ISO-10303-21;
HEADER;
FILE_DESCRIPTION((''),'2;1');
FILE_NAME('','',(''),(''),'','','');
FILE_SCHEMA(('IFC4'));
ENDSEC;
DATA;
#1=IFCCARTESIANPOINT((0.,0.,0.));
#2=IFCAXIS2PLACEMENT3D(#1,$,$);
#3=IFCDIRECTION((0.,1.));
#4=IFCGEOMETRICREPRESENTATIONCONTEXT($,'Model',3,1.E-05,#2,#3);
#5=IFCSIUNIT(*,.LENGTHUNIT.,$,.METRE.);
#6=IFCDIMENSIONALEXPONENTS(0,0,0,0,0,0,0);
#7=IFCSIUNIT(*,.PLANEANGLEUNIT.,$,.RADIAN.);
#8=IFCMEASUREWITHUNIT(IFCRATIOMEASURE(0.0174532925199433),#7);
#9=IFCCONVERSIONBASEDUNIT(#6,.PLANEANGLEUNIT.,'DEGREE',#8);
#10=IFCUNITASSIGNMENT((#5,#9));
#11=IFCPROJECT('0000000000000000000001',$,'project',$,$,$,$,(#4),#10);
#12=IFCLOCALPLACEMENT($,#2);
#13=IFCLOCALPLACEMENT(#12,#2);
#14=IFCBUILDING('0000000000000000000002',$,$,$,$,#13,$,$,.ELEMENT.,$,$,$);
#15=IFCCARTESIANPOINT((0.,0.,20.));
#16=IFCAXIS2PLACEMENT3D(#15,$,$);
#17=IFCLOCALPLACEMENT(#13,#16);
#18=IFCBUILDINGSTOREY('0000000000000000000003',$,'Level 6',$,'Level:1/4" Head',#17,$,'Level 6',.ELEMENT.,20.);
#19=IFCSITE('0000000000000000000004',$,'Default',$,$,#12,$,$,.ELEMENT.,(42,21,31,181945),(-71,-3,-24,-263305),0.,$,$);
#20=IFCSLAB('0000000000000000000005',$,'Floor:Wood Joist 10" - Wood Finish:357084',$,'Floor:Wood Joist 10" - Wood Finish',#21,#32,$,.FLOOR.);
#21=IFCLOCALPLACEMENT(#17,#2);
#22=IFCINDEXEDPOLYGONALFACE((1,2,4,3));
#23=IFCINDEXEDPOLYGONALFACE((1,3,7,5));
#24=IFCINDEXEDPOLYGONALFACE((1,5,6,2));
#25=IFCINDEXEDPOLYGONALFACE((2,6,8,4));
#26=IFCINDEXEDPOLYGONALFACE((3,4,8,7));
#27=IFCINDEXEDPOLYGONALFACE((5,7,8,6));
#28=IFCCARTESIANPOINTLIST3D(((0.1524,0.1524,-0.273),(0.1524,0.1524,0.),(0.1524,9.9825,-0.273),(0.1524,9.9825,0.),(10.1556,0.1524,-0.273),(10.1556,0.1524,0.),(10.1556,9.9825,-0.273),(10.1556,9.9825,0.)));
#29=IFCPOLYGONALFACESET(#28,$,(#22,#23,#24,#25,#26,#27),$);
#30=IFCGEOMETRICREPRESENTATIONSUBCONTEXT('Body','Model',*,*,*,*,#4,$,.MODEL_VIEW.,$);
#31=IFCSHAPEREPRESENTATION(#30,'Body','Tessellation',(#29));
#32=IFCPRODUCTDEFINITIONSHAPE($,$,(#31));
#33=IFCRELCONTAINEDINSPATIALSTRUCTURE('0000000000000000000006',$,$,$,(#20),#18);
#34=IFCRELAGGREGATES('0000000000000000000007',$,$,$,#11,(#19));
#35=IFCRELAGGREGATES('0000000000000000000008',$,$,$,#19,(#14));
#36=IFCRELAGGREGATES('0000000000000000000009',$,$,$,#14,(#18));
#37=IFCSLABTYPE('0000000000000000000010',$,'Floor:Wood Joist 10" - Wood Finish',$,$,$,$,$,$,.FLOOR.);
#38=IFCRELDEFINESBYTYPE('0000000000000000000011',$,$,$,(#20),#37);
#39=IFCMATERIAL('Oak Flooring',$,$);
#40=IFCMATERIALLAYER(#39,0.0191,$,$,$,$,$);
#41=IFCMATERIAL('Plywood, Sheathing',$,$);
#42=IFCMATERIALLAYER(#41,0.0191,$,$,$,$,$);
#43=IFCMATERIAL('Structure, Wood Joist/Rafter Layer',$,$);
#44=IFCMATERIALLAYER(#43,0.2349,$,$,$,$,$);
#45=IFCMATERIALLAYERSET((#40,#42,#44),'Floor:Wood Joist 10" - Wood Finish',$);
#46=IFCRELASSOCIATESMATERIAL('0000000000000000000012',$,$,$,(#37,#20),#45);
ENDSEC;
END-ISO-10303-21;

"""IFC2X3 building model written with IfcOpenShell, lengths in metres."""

from ifc_helpers import new_model, entity, si_unit, converted_unit, direction, frame, frame_2d, origin, place, context, subcontext, project, spatial, rectangle, extrude, material, layer, layer_set, layer_usage, type_object, element, save


model = new_model("IFC2X3")

# Units and contexts
model_context = context("Model", 3, precision=1e-05, world=origin(), true_north=direction((0.0, 1.0)))
body_context = subcontext(model_context, "Body", "Model", "MODEL_VIEW")
ifc_project = project(units=[si_unit("LENGTHUNIT", "METRE"), converted_unit("PLANEANGLEUNIT", "DEGREE", entity("IfcRatioMeasure", 0.0174532925199433), si_unit("PLANEANGLEUNIT", "RADIAN"), dimensions=[0, 0, 0, 0, 0, 0, 0])], contexts=[model_context])

# Site, building, storey
site_placement = place(None, origin())
site = spatial("IfcSite", under=ifc_project, at=site_placement, Name="Default", CompositionType="ELEMENT", RefLatitude=(42, 21, 31, 181945), RefLongitude=(-71, -3, -24, -263305), RefElevation=0.0)
building_placement = place(site_placement, origin())
building = spatial("IfcBuilding", under=site, at=building_placement, CompositionType="ELEMENT")
storey_placement = place(building_placement, frame((0.0, 0.0, 20.0)))
storey = spatial("IfcBuildingStorey", under=building, at=storey_placement, Name="Level 6", ObjectType="Level:1/4\" Head", LongName="Level 6", CompositionType="ELEMENT", Elevation=20.0)

# Slab
ifc_material_1 = material(Name="Oak Flooring")
ifc_layer_1 = layer(ifc_material_1, 0.0191)
ifc_material_2 = material(Name="Plywood, Sheathing")
ifc_layer_2 = layer(ifc_material_2, 0.0191)
ifc_material_3 = material(Name="Structure, Wood Joist/Rafter Layer")
ifc_layer_3 = layer(ifc_material_3, 0.2349)
ifc_layer_set = layer_set([ifc_layer_1, ifc_layer_2, ifc_layer_3], Name="Floor:Wood Joist 10\" - Wood Finish")
ifc_layer_usage = layer_usage(ifc_layer_set, "AXIS3", "POSITIVE", 0.0)
slab_type = type_object("IfcSlabType", Name="Floor:Wood Joist 10\" - Wood Finish", PredefinedType="FLOOR", material=ifc_layer_set)
slab_placement = place(storey_placement, origin())
element("IfcSlab", 1, at=slab_placement, inside=storey, type_object=slab_type, material=ifc_layer_usage, Name="Floor:Wood Joist 10\" - Wood Finish:357084", ObjectType="Floor:Wood Joist 10\" - Wood Finish", PredefinedType="FLOOR", context=body_context, shape_type="SweptSolid", body=[
    extrude(rectangle(XDim=9.8301, YDim=10.0032, at=frame_2d((0.0, 0.0), x_axis=(1.0, 0.0))), frame((5.154, 5.0675, 0.0), z_axis=(0.0, 0.0, -1.0), x_axis=(0.0, 1.0, 0.0)), (0.0, 0.0, 1.0), 0.273),
])

save(model, "model.ifc")
